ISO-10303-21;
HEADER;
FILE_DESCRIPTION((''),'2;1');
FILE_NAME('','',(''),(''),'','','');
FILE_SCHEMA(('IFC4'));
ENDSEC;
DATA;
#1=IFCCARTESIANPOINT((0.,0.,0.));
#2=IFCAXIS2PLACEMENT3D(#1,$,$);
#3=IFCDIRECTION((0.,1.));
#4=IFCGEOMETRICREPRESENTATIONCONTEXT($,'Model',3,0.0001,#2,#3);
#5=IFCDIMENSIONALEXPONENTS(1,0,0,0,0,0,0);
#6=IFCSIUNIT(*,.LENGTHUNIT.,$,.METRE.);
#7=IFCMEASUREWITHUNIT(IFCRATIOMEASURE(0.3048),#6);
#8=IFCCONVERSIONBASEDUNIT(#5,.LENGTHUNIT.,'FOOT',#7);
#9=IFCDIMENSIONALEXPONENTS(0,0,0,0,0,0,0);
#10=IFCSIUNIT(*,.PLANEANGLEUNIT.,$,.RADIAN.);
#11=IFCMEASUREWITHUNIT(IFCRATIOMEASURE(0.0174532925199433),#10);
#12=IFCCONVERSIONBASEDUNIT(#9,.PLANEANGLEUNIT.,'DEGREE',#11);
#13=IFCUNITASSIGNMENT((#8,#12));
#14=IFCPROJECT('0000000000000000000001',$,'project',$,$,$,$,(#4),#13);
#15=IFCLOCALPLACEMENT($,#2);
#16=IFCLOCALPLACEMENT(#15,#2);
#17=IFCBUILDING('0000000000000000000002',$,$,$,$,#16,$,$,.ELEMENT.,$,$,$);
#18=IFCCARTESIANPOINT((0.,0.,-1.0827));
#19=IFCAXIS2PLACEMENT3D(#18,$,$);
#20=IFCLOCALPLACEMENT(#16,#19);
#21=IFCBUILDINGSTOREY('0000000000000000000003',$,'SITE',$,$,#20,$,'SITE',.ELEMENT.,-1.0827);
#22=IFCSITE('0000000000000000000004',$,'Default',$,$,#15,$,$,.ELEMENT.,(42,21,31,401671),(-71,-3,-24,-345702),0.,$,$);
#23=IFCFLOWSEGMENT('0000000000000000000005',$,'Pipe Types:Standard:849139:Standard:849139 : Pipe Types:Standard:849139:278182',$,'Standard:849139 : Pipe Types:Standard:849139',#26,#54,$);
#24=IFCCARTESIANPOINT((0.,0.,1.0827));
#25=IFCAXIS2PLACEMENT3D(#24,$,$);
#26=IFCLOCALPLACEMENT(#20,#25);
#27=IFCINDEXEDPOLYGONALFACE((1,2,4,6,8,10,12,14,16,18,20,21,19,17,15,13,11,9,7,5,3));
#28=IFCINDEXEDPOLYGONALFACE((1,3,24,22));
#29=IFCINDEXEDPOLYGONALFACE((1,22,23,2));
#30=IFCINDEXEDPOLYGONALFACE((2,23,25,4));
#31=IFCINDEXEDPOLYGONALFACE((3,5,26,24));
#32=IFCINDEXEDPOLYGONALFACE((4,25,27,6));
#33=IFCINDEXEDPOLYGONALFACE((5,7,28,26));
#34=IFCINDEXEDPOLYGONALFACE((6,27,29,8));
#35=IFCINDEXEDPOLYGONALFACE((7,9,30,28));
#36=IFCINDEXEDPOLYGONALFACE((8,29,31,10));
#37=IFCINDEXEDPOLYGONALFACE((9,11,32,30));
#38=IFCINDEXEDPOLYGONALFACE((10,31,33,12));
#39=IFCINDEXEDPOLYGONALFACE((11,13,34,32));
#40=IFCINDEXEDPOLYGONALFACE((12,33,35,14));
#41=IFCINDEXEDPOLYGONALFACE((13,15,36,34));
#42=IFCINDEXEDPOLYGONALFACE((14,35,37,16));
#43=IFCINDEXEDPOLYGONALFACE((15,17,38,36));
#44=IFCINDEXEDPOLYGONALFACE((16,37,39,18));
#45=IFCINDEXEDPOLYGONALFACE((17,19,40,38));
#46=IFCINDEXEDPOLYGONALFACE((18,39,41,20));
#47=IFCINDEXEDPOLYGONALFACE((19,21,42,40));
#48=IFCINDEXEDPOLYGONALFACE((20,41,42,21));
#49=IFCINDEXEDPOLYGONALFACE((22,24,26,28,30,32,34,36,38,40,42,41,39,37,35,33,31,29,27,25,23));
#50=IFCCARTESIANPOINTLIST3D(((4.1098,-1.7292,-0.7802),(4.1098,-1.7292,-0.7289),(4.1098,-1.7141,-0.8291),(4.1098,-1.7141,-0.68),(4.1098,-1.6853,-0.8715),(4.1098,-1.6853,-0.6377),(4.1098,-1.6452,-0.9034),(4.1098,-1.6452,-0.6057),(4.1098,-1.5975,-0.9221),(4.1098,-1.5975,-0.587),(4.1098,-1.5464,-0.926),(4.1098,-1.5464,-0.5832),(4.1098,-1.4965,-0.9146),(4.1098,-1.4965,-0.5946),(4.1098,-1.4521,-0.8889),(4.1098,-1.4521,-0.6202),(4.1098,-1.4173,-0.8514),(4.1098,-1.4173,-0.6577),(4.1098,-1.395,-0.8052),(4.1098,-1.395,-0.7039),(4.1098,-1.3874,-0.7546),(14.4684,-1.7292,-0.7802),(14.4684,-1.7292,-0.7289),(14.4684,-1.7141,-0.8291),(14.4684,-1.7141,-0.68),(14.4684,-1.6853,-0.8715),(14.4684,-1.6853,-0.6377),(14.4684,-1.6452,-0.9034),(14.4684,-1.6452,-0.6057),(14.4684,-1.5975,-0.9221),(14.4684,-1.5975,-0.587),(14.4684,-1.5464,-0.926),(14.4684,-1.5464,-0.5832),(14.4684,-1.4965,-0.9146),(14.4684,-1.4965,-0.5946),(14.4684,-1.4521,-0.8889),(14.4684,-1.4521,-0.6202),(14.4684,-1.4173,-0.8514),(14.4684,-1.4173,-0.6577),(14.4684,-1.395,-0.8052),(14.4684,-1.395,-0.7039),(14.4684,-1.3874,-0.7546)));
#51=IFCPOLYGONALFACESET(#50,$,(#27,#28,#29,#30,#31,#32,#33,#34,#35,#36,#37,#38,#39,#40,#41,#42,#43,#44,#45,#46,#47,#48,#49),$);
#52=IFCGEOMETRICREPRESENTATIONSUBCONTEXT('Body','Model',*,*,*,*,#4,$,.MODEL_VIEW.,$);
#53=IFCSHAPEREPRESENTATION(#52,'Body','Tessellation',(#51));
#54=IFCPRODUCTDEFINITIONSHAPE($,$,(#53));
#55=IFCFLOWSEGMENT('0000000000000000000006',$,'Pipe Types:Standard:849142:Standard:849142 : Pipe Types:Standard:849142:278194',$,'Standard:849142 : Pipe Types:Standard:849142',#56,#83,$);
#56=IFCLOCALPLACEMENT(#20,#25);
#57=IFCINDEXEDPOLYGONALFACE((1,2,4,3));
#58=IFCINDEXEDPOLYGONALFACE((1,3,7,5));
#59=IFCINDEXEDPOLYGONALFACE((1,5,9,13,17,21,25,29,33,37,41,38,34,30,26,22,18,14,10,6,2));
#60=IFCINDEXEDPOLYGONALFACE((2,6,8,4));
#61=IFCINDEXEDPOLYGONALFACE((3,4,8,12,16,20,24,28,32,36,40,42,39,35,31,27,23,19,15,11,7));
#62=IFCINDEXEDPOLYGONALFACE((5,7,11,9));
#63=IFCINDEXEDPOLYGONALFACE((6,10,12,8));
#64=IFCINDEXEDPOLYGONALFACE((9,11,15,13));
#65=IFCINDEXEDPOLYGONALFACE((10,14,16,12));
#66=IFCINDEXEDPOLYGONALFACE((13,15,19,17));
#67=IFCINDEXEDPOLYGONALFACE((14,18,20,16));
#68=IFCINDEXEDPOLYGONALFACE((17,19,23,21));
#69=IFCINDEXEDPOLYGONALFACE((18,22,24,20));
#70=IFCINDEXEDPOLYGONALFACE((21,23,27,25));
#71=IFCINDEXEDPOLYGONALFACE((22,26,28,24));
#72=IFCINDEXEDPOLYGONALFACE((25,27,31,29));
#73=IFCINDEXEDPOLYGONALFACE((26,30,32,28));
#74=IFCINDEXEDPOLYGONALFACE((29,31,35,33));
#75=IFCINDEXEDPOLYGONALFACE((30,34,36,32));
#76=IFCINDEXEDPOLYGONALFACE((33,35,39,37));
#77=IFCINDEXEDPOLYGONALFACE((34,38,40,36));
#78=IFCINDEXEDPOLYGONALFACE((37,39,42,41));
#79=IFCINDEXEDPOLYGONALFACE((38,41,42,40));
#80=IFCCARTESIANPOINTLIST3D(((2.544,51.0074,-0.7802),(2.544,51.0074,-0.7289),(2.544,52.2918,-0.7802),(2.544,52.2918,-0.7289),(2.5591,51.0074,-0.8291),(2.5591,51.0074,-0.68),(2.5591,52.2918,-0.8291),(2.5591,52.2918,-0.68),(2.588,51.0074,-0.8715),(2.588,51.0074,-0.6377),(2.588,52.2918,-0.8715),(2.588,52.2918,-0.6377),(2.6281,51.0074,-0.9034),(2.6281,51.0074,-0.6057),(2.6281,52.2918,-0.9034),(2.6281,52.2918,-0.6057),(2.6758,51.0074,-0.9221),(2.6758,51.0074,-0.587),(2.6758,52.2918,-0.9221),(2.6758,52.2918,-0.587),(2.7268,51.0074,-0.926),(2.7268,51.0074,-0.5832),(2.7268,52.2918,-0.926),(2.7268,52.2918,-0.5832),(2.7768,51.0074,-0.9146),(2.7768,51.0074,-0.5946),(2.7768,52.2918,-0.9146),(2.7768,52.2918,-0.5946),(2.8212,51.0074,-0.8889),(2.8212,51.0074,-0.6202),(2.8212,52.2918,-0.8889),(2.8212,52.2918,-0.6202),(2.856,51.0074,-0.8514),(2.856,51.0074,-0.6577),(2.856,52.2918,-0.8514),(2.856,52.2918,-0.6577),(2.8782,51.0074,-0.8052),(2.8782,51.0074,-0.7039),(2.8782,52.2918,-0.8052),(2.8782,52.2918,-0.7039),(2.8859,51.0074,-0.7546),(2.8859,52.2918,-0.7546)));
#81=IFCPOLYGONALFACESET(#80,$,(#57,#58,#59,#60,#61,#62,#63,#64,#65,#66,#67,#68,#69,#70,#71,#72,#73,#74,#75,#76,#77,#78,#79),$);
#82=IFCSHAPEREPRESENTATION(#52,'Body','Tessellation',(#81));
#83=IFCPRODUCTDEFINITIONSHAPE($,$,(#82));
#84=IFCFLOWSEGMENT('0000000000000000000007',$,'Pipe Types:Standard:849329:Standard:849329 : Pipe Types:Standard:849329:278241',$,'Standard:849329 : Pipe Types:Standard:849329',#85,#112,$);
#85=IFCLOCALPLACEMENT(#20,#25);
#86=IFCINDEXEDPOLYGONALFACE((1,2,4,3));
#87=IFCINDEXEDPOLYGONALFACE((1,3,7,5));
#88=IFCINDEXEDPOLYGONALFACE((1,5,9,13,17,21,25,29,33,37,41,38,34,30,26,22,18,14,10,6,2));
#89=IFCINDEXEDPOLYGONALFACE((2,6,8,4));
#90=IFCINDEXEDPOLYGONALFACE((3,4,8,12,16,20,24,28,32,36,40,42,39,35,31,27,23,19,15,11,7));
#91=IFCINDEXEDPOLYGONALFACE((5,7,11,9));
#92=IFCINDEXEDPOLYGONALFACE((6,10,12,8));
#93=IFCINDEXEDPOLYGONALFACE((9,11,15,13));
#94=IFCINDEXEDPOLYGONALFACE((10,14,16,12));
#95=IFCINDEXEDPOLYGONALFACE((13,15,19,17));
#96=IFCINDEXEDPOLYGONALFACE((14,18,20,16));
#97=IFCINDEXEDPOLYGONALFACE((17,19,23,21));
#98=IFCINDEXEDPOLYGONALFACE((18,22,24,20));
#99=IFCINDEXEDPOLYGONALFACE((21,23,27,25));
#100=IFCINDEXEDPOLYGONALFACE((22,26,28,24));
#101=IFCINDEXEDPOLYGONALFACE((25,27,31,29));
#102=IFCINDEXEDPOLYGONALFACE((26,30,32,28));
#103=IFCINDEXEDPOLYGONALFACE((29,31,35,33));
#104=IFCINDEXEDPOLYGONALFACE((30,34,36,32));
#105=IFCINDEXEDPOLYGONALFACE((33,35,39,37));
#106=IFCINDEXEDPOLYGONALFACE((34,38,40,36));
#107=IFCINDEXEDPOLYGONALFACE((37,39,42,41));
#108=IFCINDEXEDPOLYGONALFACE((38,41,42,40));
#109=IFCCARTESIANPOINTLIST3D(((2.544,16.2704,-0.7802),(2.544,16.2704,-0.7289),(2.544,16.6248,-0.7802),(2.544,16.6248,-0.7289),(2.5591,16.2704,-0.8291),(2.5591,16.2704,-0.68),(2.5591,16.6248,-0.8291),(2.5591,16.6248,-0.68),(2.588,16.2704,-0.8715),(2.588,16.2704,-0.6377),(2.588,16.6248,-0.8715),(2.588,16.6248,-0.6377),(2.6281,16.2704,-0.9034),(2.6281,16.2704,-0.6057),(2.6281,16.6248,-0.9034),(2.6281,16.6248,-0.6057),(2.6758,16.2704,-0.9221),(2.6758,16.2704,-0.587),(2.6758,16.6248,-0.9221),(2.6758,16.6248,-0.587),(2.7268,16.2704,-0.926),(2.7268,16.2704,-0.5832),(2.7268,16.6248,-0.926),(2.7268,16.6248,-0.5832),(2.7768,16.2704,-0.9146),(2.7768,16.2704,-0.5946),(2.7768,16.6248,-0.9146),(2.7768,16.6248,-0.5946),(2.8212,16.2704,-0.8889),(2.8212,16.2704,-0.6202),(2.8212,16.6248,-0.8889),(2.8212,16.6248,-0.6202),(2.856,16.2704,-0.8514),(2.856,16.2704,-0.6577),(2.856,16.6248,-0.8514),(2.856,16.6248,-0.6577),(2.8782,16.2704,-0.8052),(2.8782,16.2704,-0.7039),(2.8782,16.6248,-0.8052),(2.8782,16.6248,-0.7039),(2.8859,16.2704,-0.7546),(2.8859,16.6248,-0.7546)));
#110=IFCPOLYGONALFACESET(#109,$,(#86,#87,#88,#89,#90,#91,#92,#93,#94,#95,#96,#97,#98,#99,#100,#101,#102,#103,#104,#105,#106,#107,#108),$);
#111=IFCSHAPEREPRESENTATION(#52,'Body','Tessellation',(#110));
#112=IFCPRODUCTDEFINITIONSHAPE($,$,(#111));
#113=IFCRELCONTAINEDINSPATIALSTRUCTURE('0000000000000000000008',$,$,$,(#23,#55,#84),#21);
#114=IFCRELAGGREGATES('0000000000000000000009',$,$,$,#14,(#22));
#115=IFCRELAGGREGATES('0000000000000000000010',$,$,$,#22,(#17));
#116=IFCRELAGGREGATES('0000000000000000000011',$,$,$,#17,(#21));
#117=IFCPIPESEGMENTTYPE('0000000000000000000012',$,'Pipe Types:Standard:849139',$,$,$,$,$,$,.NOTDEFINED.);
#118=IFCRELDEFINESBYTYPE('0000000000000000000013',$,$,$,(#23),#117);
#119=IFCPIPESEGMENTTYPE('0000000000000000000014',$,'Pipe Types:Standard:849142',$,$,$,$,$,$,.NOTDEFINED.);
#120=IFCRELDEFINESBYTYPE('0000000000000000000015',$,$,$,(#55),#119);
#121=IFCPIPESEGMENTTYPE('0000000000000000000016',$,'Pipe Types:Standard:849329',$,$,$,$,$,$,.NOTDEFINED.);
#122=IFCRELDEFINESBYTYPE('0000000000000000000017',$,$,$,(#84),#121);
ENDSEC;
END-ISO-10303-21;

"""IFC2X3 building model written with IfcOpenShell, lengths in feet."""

from ifc_helpers import new_model, entity, si_unit, converted_unit, direction, frame, frame_2d, origin, place, context, subcontext, project, spatial, circle, extrude, source, transform, mapped, type_object, type_shapes, element, save


model = new_model("IFC2X3")

# Units and contexts
model_context = context("Model", 3, precision=0.0001, world=origin(), true_north=direction((0.0, 1.0)))
body_context = subcontext(model_context, "Body", "Model", "MODEL_VIEW")
ifc_project = project(units=[converted_unit("LENGTHUNIT", "FOOT", entity("IfcRatioMeasure", 0.3048), si_unit("LENGTHUNIT", "METRE"), dimensions=[1, 0, 0, 0, 0, 0, 0]), converted_unit("PLANEANGLEUNIT", "DEGREE", entity("IfcRatioMeasure", 0.0174532925199433), si_unit("PLANEANGLEUNIT", "RADIAN"), dimensions=[0, 0, 0, 0, 0, 0, 0])], contexts=[model_context])

# Site, building, storey
site_placement = place(None, origin())
site = spatial("IfcSite", under=ifc_project, at=site_placement, Name="Default", CompositionType="ELEMENT", RefLatitude=(42, 21, 31, 401671), RefLongitude=(-71, -3, -24, -345702), RefElevation=0.0)
building_placement = place(site_placement, origin())
building = spatial("IfcBuilding", under=site, at=building_placement, CompositionType="ELEMENT")
storey_placement = place(building_placement, frame((0.0, 0.0, -1.0827)))
storey = spatial("IfcBuildingStorey", under=building, at=storey_placement, Name="SITE", LongName="SITE", CompositionType="ELEMENT", Elevation=-1.0827)

# Flow segments
pipe_segment_type_1 = type_object("IfcPipeSegmentType", Name="Pipe Types:Standard:849139", PredefinedType="NOTDEFINED")
shared_shape_1 = source(origin(), body_context, "Body", "SweptSolid", [
    extrude(circle(Radius=0.1719, at=frame_2d((0.0, 0.0), x_axis=(1.0, 0.0))), frame((4.1098, -1.5593, -0.7546), z_axis=(1.0, 0.0, 0.0), x_axis=(0.0, 1.0, 0.0)), (0.0, 0.0, 1.0), 10.3585),
])
type_shapes(pipe_segment_type_1, [shared_shape_1])
flow_segment_1_placement = place(storey_placement, frame((0.0, 0.0, 1.0827)))
element("IfcFlowSegment", 1, at=flow_segment_1_placement, inside=storey, type_object=pipe_segment_type_1, Name="Pipe Types:Standard:849139:Standard:849139 : Pipe Types:Standard:849139:278182", ObjectType="Standard:849139 : Pipe Types:Standard:849139", context=body_context, shape_type="MappedRepresentation", body=[
    mapped(shared_shape_1, transform((0.0, 0.0, 0.0), scale=1.0)),
])
pipe_segment_type_2 = type_object("IfcPipeSegmentType", Name="Pipe Types:Standard:849142", PredefinedType="NOTDEFINED")
shared_shape_2 = source(origin(), body_context, "Body", "SweptSolid", [
    extrude(circle(Radius=0.1719, at=frame_2d((0.0, 0.0), x_axis=(1.0, 0.0))), frame((2.714, 51.0074, -0.7546), z_axis=(0.0, 1.0, 0.0), x_axis=(1.0, 0.0, 0.0)), (0.0, 0.0, 1.0), 1.2845),
])
type_shapes(pipe_segment_type_2, [shared_shape_2])
flow_segment_2_placement = place(storey_placement, frame((0.0, 0.0, 1.0827)))
element("IfcFlowSegment", 2, at=flow_segment_2_placement, inside=storey, type_object=pipe_segment_type_2, Name="Pipe Types:Standard:849142:Standard:849142 : Pipe Types:Standard:849142:278194", ObjectType="Standard:849142 : Pipe Types:Standard:849142", context=body_context, shape_type="MappedRepresentation", body=[
    mapped(shared_shape_2, transform((0.0, 0.0, 0.0), scale=1.0)),
])
pipe_segment_type_3 = type_object("IfcPipeSegmentType", Name="Pipe Types:Standard:849329", PredefinedType="NOTDEFINED")
shared_shape_3 = source(origin(), body_context, "Body", "SweptSolid", [
    extrude(circle(Radius=0.1719, at=frame_2d((0.0, 0.0), x_axis=(1.0, 0.0))), frame((2.714, 16.2704, -0.7546), z_axis=(0.0, 1.0, 0.0), x_axis=(1.0, 0.0, 0.0)), (0.0, 0.0, 1.0), 0.3544),
])
type_shapes(pipe_segment_type_3, [shared_shape_3])
flow_segment_3_placement = place(storey_placement, frame((0.0, 0.0, 1.0827)))
element("IfcFlowSegment", 3, at=flow_segment_3_placement, inside=storey, type_object=pipe_segment_type_3, Name="Pipe Types:Standard:849329:Standard:849329 : Pipe Types:Standard:849329:278241", ObjectType="Standard:849329 : Pipe Types:Standard:849329", context=body_context, shape_type="MappedRepresentation", body=[
    mapped(shared_shape_3, transform((0.0, 0.0, 0.0), scale=1.0)),
])

save(model, "model.ifc")
